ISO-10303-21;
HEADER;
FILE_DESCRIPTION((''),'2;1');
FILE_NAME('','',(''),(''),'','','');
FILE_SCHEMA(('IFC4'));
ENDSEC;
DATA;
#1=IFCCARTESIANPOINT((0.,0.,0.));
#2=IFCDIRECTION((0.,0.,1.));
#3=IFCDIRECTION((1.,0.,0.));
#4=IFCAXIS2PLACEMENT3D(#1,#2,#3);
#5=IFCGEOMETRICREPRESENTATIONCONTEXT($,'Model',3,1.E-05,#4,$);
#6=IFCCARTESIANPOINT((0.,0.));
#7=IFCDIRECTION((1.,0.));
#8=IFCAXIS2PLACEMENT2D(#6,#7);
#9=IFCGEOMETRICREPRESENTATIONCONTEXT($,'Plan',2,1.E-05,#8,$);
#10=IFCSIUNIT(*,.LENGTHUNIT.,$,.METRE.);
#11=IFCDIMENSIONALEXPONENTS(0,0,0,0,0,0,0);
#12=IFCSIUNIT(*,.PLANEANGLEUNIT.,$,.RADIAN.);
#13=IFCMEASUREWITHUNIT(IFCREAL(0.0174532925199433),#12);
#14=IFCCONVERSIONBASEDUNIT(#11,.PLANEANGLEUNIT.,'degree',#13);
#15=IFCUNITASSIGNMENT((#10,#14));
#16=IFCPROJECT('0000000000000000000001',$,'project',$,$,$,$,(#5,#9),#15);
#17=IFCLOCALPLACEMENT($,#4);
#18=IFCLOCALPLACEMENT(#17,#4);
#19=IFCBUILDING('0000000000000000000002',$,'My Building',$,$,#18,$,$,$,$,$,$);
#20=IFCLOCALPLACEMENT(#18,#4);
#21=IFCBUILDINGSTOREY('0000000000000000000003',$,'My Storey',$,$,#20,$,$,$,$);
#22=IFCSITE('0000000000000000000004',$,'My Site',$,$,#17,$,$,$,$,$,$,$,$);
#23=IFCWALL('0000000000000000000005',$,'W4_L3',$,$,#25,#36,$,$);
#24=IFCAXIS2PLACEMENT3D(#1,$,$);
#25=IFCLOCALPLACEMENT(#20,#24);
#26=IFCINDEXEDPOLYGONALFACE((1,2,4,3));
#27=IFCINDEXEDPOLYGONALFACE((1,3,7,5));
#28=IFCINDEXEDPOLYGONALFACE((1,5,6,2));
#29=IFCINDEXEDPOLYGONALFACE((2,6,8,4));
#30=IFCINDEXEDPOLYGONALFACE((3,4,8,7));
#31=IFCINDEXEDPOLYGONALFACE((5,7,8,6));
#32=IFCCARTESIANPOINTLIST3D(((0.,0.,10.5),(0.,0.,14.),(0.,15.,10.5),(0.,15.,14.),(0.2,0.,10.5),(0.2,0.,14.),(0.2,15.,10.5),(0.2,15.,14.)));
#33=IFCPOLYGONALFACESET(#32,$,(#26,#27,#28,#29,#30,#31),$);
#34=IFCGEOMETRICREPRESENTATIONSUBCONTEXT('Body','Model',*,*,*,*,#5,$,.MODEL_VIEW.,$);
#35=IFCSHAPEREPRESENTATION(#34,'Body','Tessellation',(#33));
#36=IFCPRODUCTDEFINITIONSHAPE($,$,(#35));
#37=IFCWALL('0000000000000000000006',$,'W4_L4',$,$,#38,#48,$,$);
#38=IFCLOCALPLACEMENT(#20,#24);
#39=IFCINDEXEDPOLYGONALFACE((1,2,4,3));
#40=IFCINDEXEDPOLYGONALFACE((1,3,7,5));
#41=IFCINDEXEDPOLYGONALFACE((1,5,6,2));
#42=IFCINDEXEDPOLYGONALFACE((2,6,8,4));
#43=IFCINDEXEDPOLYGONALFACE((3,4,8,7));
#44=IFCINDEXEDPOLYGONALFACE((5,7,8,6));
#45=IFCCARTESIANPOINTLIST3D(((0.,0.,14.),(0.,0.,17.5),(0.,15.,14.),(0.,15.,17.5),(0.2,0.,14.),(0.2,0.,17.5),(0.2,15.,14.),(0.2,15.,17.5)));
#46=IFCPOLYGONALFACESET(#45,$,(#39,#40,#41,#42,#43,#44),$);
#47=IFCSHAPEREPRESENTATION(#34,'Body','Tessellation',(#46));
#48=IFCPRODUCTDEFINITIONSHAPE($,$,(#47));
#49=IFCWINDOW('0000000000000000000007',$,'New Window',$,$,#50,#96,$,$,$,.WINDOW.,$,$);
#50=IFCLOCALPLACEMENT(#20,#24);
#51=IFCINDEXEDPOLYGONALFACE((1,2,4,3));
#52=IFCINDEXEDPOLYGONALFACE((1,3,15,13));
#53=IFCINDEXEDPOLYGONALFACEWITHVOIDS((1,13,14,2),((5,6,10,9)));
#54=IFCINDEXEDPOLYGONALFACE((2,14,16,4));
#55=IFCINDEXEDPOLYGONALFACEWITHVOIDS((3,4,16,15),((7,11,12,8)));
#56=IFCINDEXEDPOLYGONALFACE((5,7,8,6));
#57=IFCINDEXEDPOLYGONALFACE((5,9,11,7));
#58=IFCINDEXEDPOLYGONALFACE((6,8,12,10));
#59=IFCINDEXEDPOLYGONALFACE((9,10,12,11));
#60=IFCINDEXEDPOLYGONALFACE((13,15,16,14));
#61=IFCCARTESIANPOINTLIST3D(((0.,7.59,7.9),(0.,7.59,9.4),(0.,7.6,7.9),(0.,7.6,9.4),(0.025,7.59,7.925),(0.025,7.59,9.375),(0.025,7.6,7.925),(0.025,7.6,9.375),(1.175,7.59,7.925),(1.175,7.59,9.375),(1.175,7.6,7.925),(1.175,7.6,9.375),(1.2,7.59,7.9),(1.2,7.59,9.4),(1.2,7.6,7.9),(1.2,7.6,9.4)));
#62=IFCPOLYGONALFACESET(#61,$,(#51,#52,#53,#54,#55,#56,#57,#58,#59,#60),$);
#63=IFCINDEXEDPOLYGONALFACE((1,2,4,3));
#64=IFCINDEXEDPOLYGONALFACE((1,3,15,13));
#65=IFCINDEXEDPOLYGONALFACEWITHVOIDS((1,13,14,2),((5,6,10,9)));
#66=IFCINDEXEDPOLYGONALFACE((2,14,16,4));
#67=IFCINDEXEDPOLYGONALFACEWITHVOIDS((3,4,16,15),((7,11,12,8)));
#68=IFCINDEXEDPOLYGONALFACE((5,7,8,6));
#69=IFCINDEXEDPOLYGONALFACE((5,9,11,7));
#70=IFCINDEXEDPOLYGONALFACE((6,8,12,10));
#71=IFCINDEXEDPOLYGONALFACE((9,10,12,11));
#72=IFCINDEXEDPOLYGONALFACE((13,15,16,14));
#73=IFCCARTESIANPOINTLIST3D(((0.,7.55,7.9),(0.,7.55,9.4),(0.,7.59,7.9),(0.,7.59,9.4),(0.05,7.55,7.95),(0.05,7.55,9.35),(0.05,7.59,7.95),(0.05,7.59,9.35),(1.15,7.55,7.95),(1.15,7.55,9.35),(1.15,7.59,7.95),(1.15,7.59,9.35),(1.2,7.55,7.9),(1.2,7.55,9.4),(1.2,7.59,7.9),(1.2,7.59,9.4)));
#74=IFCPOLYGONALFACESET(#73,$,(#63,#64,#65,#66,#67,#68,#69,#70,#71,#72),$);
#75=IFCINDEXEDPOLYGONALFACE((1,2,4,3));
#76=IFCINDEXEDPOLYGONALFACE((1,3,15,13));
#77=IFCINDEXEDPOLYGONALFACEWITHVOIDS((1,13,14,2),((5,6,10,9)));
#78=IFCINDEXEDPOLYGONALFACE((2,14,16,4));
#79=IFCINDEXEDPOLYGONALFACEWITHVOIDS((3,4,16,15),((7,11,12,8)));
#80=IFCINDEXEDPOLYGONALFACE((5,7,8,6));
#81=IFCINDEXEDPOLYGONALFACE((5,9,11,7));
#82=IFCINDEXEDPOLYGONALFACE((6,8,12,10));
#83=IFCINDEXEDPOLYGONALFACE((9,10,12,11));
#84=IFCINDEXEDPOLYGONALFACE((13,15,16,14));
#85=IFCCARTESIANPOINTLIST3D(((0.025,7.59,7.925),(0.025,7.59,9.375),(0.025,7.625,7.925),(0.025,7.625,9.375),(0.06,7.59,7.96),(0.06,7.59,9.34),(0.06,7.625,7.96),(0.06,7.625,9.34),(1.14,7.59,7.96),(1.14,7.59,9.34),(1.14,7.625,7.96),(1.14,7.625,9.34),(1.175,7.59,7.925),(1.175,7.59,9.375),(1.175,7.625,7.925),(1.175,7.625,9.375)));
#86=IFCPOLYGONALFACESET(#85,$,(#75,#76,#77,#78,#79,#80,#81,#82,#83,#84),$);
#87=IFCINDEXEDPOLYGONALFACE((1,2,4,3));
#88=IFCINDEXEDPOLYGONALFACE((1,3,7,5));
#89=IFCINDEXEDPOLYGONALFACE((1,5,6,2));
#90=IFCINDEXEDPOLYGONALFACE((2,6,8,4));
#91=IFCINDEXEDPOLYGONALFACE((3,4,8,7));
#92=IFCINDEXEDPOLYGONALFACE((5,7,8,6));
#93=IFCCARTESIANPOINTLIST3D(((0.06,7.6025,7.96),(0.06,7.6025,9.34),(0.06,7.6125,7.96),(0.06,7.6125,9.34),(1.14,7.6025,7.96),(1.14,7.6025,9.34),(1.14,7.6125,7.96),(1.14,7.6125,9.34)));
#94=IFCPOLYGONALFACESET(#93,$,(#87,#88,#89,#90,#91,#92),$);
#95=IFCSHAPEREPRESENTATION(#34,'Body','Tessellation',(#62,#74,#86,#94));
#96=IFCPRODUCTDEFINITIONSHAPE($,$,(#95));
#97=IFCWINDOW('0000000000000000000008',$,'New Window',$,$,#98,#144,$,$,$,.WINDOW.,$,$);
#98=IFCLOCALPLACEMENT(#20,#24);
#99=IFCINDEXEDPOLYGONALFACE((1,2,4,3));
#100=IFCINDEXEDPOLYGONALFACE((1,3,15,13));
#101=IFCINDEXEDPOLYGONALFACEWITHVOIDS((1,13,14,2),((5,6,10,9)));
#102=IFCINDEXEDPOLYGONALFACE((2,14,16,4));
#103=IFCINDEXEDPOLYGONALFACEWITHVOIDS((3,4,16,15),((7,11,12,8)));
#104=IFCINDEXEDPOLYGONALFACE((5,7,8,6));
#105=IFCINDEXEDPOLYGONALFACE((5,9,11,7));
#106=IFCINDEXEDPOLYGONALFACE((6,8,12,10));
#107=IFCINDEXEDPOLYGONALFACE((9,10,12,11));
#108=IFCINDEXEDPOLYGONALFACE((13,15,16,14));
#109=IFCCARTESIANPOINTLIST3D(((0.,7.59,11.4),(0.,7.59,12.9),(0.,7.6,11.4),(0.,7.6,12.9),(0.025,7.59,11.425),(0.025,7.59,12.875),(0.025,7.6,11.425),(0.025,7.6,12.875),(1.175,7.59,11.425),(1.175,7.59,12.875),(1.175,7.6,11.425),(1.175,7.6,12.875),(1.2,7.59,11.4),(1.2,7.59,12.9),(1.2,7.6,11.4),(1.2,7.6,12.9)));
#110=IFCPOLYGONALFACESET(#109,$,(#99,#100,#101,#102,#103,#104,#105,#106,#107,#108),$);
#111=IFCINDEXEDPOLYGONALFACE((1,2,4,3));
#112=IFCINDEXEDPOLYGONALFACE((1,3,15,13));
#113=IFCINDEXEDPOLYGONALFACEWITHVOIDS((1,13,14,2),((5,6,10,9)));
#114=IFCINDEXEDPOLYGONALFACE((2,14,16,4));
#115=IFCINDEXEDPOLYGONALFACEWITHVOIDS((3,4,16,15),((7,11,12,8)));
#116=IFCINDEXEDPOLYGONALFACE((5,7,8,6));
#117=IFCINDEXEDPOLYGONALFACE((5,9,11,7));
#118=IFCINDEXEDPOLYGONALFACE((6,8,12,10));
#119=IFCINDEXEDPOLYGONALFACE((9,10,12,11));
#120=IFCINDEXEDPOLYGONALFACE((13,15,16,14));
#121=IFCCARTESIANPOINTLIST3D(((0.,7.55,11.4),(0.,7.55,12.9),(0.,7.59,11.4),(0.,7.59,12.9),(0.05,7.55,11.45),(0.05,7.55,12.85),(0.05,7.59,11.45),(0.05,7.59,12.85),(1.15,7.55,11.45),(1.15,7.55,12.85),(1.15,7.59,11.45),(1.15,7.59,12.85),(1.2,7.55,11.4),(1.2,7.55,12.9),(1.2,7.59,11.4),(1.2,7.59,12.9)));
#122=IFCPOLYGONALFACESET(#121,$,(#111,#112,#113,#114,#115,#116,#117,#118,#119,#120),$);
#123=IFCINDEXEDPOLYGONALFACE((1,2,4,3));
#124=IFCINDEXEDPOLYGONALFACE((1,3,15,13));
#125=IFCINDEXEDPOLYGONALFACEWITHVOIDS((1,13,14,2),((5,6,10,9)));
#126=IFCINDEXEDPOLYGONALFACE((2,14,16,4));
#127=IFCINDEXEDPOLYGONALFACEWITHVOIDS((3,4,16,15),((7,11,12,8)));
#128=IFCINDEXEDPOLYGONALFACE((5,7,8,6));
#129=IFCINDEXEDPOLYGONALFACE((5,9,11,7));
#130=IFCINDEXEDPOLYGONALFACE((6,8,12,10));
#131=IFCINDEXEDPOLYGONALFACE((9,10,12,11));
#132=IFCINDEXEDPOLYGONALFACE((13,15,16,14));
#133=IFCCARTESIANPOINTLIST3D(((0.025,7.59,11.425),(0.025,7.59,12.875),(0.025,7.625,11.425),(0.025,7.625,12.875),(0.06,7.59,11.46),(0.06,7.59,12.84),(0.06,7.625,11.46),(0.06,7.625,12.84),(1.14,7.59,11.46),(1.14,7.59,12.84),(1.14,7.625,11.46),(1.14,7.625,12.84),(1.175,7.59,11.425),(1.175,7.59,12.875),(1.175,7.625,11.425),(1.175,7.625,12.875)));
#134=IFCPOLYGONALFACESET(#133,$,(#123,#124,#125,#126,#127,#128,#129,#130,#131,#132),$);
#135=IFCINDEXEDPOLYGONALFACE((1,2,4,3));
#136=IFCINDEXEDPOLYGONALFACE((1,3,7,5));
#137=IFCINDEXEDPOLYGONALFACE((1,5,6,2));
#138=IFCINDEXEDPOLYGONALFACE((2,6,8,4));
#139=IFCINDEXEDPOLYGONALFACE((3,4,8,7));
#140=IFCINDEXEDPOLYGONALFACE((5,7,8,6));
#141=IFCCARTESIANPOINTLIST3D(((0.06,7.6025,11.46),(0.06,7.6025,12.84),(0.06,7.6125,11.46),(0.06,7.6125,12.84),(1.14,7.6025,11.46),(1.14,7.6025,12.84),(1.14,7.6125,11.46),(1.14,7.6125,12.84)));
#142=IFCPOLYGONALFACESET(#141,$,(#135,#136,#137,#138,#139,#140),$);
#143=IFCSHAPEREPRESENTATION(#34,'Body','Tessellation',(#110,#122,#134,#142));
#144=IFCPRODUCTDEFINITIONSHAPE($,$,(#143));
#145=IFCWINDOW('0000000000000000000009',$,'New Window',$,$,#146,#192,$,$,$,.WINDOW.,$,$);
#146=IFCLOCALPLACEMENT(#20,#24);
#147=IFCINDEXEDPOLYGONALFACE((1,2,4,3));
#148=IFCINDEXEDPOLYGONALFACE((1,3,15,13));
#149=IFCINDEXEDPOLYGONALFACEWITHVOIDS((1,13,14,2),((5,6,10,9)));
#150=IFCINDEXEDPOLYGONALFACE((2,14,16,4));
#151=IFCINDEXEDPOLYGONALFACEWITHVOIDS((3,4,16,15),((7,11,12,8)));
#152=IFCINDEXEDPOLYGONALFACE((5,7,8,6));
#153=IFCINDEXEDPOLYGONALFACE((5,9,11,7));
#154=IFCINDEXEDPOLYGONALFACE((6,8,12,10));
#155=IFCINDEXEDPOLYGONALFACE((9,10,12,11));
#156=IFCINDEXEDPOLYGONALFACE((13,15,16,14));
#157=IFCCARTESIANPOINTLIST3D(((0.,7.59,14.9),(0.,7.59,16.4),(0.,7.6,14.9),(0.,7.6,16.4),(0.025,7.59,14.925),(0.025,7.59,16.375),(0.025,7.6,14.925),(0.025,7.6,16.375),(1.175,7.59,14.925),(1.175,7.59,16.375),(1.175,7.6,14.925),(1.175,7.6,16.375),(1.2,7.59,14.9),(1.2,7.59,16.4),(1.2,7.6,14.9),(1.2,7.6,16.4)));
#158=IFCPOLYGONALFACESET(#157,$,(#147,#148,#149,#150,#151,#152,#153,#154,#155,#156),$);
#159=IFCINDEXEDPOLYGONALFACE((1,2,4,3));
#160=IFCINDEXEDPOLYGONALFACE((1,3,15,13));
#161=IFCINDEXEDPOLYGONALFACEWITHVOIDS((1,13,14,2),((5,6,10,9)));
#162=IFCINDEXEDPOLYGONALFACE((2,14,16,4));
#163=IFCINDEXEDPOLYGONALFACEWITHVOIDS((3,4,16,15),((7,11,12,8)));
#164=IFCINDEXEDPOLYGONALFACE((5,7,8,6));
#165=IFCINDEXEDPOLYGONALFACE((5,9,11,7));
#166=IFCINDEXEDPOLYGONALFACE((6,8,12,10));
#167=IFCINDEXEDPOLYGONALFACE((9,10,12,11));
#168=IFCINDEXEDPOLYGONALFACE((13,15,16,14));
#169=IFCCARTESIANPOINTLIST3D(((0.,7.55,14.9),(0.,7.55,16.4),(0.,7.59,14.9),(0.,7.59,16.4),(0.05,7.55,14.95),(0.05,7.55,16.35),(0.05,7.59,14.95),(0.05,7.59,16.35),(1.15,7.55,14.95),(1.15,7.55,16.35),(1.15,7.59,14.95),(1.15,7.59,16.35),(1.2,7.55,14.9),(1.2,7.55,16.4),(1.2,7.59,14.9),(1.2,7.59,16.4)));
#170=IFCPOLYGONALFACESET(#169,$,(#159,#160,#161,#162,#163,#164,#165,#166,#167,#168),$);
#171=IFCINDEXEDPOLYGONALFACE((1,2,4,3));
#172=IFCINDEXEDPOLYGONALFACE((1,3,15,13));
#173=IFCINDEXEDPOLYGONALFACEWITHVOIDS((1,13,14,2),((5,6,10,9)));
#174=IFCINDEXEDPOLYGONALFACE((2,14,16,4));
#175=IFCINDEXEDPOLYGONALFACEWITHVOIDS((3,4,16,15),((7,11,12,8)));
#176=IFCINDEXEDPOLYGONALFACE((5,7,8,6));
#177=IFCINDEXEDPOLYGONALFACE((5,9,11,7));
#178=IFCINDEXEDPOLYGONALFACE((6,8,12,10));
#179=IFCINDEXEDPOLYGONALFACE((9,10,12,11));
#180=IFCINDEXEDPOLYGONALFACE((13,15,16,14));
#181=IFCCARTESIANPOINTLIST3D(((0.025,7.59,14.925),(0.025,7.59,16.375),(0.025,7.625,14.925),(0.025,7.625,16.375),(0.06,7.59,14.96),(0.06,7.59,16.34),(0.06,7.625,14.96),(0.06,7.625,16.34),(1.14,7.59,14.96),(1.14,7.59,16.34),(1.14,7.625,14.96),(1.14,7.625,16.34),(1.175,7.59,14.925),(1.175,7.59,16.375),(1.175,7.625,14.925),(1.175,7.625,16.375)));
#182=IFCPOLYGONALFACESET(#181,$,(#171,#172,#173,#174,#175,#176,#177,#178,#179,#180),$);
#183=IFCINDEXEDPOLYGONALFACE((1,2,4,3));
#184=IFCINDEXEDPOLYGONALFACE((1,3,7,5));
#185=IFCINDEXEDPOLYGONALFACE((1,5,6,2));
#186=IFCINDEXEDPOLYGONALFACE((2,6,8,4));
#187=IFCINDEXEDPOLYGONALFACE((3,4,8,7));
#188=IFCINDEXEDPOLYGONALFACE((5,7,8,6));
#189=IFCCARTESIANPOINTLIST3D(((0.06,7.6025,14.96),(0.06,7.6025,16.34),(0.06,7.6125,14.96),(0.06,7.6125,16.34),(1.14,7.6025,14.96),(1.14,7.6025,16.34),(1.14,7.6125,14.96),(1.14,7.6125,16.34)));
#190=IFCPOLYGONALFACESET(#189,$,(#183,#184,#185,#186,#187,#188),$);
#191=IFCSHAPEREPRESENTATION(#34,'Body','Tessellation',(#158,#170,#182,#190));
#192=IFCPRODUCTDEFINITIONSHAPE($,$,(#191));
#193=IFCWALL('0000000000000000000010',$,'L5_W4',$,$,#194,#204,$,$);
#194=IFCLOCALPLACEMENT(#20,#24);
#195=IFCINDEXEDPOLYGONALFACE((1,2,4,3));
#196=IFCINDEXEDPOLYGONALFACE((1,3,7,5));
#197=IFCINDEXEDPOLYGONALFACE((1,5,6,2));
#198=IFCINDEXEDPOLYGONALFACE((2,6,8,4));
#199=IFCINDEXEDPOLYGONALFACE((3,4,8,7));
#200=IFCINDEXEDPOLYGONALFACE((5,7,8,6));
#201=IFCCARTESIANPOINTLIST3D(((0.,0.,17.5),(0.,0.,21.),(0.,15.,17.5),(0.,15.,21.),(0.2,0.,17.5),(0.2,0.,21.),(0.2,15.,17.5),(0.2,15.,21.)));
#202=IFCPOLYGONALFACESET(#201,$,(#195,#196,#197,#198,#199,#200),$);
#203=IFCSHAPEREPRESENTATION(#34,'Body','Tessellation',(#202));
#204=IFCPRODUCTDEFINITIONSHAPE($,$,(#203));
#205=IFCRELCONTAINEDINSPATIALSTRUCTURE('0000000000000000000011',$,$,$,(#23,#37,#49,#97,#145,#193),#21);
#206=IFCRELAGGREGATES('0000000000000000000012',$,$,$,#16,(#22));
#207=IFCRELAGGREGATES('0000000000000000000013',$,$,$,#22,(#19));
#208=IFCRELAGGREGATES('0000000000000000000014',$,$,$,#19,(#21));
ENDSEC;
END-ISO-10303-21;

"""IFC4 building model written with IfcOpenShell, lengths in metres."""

from ifc_helpers import new_model, entity, si_unit, converted_unit, frame, origin_with_axes, origin_2d_with_axis, place, context, subcontext, project, spatial, line, indexed_curve, outline, extrude, element, save


model = new_model("IFC4")

# Units and contexts
model_context = context("Model", 3, precision=1e-05, world=origin_with_axes())
plan_context = context("Plan", 2, precision=1e-05, world=origin_2d_with_axis())
body_context = subcontext(model_context, "Body", "Model", "MODEL_VIEW")
ifc_project = project(units=[si_unit("LENGTHUNIT", "METRE"), converted_unit("PLANEANGLEUNIT", "degree", entity("IfcReal", 0.0174532925199433), si_unit("PLANEANGLEUNIT", "RADIAN"), dimensions=[0, 0, 0, 0, 0, 0, 0])], contexts=[model_context, plan_context])

# Site, building, storey
site_placement = place(None, origin_with_axes())
site = spatial("IfcSite", under=ifc_project, at=site_placement, Name="My Site")
building_placement = place(site_placement, origin_with_axes())
building = spatial("IfcBuilding", under=site, at=building_placement, Name="My Building")
storey_placement = place(building_placement, origin_with_axes())
storey = spatial("IfcBuildingStorey", under=building, at=storey_placement, Name="My Storey")

# Walls
for number, where, z_axis, x_axis, name in (
    (1, (0.0, 15.0, 10.5), (0.0, 0.0, 1.0), (0.0, -1.0, 0.0), "W4_L3"),
    (2, (0.0, 15.0, 14.0), (0.0, 0.0, 1.0), (0.0, -1.0, 0.0), "W4_L4"),
):
    element("IfcWall", number, at=place(storey_placement, frame(where, z_axis=z_axis, x_axis=x_axis)), inside=storey, Name=name, context=body_context, shape_type="SweptSolid", body=[
        extrude(outline(indexed_curve([(0.0, 0.0), (0.0, 0.2), (15.0, 0.2), (15.0, 0.0), (0.0, 0.0)], self_intersect=False)), origin_with_axes(), (0.0, 0.0, 1.0), 3.5),
    ])

# Windows
for number, where, z_axis, x_axis, name in (
    (3, (0.0, 7.5, 7.9), (0.0, 0.0, 1.0), (1.0, 0.0, 0.0), "New Window"),
    (4, (0.0, 7.5, 11.4), (0.0, 0.0, 1.0), (1.0, 0.0, 0.0), "New Window"),
    (5, (0.0, 7.5, 14.9), (0.0, 0.0, 1.0), (1.0, 0.0, 0.0), "New Window"),
):
    element("IfcWindow", number, at=place(storey_placement, frame(where, z_axis=z_axis, x_axis=x_axis)), inside=storey, Name=name, PredefinedType="WINDOW", context=body_context, shape_type="SweptSolid", body=[
        extrude(outline(indexed_curve([(0.0, 0.0), (1.2, 0.0), (1.2, 1.5), (0.0, 1.5)], segments=[line(1, 2, 3, 4, 1)]), holes=[indexed_curve([(0.025, 0.025), (1.175, 0.025), (1.175, 1.475), (0.025, 1.475)], segments=[line(1, 2, 3, 4, 1)])]), frame((0.0, 0.09, 0.0), z_axis=(0.0, -1.0, 0.0), x_axis=(1.0, 0.0, 0.0)), (0.0, 0.0, -1.0), 0.01),
        extrude(outline(indexed_curve([(0.0, 0.0), (1.2, 0.0), (1.2, 1.5), (0.0, 1.5)], segments=[line(1, 2, 3, 4, 1)]), holes=[indexed_curve([(0.05, 0.05), (1.15, 0.05), (1.15, 1.45), (0.05, 1.45)], segments=[line(1, 2, 3, 4, 1)])]), frame((0.0, 0.05, 0.0), z_axis=(0.0, -1.0, 0.0), x_axis=(1.0, 0.0, 0.0)), (0.0, 0.0, -1.0), 0.04),
        extrude(outline(indexed_curve([(0.0, 0.0), (1.15, 0.0), (1.15, 1.45), (0.0, 1.45)], segments=[line(1, 2, 3, 4, 1)]), holes=[indexed_curve([(0.035, 0.035), (1.115, 0.035), (1.115, 1.415), (0.035, 1.415)], segments=[line(1, 2, 3, 4, 1)])]), frame((0.025, 0.09, 0.025), z_axis=(0.0, -1.0, 0.0), x_axis=(1.0, 0.0, 0.0)), (0.0, 0.0, -1.0), 0.035),
        extrude(outline(indexed_curve([(0.035, 0.035), (1.115, 0.035), (1.115, 1.415), (0.035, 1.415)], segments=[line(1, 2, 3, 4, 1)])), frame((0.025, 0.1025, 0.025), z_axis=(0.0, -1.0, 0.0), x_axis=(1.0, 0.0, 0.0)), (0.0, 0.0, -1.0), 0.01),
    ])

# Wall
for number, where, z_axis, x_axis, name in (
    (6, (0.0, 15.0, 17.5), (0.0, 0.0, 1.0), (0.0, -1.0, 0.0), "L5_W4"),
):
    element("IfcWall", number, at=place(storey_placement, frame(where, z_axis=z_axis, x_axis=x_axis)), inside=storey, Name=name, context=body_context, shape_type="SweptSolid", body=[
        extrude(outline(indexed_curve([(0.0, 0.0), (0.0, 0.2), (15.0, 0.2), (15.0, 0.0), (0.0, 0.0)], self_intersect=False)), origin_with_axes(), (0.0, 0.0, 1.0), 3.5),
    ])

save(model, "model.ifc")
